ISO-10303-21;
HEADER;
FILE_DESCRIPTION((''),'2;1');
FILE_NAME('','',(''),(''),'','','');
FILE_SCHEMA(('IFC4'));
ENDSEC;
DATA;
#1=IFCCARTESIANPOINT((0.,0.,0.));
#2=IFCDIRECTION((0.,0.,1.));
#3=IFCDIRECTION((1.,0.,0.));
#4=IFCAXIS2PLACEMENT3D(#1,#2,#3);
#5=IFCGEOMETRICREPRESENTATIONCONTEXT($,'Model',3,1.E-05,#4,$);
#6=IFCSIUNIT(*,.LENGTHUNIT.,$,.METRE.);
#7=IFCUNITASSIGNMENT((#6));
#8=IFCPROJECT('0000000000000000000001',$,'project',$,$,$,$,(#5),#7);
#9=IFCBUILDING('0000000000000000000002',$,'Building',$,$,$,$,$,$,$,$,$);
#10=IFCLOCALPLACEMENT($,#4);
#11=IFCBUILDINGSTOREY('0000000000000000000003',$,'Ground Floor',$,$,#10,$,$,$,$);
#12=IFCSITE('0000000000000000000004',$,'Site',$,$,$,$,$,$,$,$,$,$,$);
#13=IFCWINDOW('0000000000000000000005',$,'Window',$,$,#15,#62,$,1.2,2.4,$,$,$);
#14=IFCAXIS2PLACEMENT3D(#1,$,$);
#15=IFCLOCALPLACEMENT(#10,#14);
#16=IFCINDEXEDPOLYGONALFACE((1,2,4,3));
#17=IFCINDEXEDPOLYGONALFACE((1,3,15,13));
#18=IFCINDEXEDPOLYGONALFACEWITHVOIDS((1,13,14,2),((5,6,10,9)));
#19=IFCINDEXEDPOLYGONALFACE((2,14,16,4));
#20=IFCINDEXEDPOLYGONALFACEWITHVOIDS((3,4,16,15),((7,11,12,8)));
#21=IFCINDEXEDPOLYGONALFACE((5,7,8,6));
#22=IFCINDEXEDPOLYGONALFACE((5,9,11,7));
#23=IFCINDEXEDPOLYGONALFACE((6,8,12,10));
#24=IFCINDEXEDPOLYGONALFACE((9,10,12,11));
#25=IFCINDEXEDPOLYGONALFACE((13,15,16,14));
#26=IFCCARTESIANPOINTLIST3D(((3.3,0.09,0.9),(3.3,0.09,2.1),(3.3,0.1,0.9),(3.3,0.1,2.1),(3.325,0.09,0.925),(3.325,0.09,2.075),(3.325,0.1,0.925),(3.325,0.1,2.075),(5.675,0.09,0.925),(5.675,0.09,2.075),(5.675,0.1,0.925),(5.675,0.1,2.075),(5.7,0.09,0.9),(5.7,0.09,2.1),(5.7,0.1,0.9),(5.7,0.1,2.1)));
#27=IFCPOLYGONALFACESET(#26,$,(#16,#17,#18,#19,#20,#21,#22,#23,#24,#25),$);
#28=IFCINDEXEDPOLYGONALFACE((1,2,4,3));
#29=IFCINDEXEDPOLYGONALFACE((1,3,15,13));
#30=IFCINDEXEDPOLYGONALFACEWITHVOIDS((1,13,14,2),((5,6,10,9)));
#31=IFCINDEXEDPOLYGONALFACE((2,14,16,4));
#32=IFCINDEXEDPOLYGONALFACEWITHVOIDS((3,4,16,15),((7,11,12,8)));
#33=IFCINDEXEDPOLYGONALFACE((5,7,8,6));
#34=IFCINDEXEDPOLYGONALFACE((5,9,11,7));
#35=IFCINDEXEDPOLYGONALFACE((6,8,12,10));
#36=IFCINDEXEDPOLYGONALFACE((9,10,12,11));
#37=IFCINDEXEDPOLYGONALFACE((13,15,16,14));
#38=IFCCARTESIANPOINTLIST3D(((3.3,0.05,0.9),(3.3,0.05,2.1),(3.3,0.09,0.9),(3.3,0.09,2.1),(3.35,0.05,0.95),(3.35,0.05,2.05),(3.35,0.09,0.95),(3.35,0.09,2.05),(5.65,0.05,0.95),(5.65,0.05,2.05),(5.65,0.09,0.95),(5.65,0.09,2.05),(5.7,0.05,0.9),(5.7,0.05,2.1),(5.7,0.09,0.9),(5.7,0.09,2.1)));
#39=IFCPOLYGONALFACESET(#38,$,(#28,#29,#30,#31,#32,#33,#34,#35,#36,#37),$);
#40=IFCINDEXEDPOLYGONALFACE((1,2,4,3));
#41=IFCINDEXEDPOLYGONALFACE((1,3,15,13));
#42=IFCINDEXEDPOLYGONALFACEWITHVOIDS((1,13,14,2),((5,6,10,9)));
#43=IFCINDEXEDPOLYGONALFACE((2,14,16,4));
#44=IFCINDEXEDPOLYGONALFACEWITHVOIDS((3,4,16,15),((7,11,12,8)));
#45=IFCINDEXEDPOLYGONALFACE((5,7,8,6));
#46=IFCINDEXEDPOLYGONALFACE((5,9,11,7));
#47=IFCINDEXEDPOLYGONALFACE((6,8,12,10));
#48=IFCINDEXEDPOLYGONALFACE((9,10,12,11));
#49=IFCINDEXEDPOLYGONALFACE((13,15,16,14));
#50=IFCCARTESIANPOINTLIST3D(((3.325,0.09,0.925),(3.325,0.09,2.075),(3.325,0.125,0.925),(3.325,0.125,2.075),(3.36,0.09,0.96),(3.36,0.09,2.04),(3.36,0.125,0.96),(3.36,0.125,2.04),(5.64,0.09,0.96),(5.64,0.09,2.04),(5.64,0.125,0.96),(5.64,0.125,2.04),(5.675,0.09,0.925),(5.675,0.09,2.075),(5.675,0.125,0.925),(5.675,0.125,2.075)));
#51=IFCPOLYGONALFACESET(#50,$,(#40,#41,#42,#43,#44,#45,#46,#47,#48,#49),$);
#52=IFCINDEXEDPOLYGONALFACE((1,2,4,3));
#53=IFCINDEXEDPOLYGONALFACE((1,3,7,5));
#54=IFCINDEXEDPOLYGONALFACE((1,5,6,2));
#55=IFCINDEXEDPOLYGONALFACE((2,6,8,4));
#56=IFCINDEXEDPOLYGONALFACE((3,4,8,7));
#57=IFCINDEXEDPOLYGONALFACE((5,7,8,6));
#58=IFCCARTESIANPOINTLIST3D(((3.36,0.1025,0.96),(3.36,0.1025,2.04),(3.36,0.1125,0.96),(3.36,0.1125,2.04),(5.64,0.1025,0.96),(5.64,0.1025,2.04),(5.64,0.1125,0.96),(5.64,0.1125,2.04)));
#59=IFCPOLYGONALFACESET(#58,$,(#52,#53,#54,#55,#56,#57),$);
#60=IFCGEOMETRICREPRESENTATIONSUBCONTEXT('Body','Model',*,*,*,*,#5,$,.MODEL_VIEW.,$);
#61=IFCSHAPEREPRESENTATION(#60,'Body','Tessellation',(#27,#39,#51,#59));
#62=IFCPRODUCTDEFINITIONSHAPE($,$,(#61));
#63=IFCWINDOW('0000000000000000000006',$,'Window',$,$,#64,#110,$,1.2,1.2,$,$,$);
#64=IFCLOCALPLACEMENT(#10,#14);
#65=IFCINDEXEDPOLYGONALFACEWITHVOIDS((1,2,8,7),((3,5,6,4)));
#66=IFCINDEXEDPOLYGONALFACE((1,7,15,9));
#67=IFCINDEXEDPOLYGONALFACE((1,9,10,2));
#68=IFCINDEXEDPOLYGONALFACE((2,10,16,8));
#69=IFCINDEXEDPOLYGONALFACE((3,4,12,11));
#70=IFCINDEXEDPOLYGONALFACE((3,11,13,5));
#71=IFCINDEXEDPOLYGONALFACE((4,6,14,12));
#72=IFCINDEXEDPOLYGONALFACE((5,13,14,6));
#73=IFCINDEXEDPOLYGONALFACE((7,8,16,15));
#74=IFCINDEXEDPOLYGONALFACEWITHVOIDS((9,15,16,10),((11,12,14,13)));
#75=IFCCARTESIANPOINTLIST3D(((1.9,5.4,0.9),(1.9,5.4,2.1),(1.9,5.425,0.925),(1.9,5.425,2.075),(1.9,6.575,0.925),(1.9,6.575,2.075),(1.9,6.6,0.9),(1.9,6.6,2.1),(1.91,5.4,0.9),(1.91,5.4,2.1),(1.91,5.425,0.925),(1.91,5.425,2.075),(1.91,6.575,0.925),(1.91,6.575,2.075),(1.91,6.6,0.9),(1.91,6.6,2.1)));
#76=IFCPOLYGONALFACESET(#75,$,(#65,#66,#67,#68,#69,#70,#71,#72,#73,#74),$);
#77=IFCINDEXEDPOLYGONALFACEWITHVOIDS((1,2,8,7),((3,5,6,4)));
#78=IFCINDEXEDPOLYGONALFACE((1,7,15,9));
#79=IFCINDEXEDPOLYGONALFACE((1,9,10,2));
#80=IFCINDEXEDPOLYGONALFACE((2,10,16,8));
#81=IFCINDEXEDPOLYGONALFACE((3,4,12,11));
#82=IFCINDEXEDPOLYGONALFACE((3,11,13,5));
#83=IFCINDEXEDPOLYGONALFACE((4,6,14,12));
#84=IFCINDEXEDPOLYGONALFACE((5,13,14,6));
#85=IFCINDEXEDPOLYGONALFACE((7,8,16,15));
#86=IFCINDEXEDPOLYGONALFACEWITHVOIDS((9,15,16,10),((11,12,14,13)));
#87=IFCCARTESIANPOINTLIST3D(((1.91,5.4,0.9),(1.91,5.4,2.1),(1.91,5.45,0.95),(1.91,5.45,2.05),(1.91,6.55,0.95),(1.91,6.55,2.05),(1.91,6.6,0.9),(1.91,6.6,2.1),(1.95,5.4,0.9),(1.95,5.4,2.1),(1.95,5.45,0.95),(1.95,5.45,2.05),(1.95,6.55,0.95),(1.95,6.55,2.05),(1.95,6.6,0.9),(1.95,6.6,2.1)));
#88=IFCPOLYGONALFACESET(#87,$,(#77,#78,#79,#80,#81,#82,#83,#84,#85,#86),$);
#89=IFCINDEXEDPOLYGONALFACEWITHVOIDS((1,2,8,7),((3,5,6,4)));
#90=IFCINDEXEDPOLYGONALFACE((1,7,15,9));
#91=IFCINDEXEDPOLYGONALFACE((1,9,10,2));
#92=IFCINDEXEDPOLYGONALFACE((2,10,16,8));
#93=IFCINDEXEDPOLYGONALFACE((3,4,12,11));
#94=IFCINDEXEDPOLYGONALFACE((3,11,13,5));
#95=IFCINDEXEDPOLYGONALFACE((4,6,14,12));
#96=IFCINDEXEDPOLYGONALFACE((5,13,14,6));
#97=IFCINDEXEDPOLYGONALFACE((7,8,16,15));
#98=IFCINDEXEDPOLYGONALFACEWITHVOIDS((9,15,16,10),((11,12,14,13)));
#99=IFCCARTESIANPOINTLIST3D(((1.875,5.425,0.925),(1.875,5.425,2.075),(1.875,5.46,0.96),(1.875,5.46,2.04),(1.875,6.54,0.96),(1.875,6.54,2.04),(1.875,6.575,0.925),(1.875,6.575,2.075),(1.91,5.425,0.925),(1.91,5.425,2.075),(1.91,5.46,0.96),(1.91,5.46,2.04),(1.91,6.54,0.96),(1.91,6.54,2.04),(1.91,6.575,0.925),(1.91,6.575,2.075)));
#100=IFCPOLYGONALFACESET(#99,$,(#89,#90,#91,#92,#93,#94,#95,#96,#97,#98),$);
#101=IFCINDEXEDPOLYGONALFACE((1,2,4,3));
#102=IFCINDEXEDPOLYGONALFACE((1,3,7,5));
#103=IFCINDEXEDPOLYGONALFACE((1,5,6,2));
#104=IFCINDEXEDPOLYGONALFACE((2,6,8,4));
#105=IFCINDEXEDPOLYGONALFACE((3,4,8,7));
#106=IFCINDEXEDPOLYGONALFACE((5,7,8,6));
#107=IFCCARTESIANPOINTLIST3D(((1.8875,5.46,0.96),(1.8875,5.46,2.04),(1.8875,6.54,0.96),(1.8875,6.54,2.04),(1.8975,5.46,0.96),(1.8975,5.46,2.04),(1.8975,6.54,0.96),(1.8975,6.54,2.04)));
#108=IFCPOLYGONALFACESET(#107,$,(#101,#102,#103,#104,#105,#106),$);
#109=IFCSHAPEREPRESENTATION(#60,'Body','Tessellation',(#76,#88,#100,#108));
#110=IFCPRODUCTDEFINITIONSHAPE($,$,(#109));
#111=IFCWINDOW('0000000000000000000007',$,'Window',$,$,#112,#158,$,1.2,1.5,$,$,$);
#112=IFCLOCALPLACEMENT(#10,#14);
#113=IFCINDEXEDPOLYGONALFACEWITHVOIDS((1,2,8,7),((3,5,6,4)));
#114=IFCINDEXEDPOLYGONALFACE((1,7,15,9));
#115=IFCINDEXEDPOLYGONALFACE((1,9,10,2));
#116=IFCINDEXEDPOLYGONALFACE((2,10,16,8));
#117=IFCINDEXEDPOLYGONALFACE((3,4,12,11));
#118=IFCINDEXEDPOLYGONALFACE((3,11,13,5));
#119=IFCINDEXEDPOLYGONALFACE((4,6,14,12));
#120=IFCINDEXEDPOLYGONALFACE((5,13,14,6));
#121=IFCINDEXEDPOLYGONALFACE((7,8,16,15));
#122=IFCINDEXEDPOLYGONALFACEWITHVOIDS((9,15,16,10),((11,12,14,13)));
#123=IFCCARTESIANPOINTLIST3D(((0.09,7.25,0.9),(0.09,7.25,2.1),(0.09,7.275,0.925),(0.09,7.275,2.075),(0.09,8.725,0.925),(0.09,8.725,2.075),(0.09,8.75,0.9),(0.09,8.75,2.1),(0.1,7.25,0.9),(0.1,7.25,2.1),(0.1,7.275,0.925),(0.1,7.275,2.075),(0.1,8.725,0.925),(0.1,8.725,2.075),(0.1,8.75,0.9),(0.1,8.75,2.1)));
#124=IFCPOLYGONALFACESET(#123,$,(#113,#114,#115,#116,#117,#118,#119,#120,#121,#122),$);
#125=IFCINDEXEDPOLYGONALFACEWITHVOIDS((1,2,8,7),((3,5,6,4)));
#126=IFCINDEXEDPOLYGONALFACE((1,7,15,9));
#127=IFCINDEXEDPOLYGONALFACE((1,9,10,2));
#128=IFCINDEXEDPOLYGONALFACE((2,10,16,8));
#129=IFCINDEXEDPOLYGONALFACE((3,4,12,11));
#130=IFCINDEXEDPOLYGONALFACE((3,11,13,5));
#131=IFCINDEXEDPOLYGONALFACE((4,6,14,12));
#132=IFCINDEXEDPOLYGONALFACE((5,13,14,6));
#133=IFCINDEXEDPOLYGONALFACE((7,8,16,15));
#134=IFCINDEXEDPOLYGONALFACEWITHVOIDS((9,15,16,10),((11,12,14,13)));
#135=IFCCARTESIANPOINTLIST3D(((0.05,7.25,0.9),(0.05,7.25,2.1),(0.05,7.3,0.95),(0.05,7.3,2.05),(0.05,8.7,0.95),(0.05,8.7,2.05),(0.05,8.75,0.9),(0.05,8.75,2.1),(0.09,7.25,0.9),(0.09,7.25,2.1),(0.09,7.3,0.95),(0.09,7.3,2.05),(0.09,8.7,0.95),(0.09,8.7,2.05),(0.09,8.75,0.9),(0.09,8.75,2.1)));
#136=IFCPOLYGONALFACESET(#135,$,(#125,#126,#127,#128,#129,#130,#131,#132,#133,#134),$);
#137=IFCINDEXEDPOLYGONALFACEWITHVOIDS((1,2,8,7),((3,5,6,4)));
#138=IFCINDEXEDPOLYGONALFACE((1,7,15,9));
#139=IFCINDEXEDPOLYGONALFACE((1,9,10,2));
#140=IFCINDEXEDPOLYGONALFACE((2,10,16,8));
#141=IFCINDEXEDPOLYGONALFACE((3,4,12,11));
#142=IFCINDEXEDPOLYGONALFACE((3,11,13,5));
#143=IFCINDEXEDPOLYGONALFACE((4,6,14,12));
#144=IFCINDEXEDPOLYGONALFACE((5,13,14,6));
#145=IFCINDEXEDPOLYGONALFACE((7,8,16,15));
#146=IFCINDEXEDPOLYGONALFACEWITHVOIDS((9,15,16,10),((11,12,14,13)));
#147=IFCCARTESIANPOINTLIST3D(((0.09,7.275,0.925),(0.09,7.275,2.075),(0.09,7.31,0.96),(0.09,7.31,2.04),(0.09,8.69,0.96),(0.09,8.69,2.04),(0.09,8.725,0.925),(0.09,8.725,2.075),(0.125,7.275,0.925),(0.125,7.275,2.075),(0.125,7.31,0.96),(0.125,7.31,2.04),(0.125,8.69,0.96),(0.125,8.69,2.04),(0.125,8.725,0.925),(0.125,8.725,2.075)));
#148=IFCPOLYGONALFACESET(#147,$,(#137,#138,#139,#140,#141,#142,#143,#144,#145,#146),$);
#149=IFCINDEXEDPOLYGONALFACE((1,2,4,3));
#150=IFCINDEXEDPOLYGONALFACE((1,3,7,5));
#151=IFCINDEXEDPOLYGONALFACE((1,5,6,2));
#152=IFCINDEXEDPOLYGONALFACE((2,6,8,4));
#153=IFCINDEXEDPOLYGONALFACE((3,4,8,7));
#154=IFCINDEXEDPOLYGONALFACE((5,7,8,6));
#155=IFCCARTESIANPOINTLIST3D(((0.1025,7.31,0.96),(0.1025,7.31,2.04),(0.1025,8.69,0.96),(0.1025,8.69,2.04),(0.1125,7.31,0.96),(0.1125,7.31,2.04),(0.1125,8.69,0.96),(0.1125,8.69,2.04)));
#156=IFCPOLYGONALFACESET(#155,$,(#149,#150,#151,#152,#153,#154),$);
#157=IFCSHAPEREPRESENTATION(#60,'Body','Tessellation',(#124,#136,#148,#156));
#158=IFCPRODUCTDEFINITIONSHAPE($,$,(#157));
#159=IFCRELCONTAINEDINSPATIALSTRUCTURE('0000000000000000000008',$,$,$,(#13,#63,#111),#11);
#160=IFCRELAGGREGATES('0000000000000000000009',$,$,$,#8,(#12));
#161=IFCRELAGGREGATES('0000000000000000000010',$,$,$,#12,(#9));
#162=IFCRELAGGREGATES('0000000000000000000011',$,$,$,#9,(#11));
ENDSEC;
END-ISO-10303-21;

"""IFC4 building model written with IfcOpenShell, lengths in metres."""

from ifc_helpers import new_model, si_unit, frame, origin_with_axes, place, context, subcontext, project, spatial, line, indexed_curve, outline, extrude, element, save


model = new_model("IFC4")

# Units and contexts
model_context = context("Model", 3, precision=1e-05, world=origin_with_axes())
body_context = subcontext(model_context, "Body", "Model", "MODEL_VIEW")
ifc_project = project(units=[si_unit("LENGTHUNIT", "METRE")], contexts=[model_context])

# Site, building, storey
site = spatial("IfcSite", under=ifc_project, Name="Site")
building = spatial("IfcBuilding", under=site, Name="Building")
storey_placement = place(None, origin_with_axes())
storey = spatial("IfcBuildingStorey", under=building, at=storey_placement, Name="Ground Floor")

# Windows
window_1_placement = place(storey_placement, frame((3.3, 0.0, 0.9), z_axis=(0.0, 0.0, 1.0), x_axis=(1.0, 0.0, 0.0)))
element("IfcWindow", 1, at=window_1_placement, inside=storey, Name="Window", OverallHeight=1.2, OverallWidth=2.4, context=body_context, shape_type="SweptSolid", body=[
    extrude(outline(indexed_curve([(0.0, 0.0), (2.4, 0.0), (2.4, 1.2), (0.0, 1.2)], segments=[line(1, 2, 3, 4, 1)]), holes=[indexed_curve([(0.025, 0.025), (2.375, 0.025), (2.375, 1.175), (0.025, 1.175)], segments=[line(1, 2, 3, 4, 1)])]), frame((0.0, 0.09, 0.0), z_axis=(0.0, -1.0, 0.0), x_axis=(1.0, 0.0, 0.0)), (0.0, 0.0, -1.0), 0.01),
    extrude(outline(indexed_curve([(0.0, 0.0), (2.4, 0.0), (2.4, 1.2), (0.0, 1.2)], segments=[line(1, 2, 3, 4, 1)]), holes=[indexed_curve([(0.05, 0.05), (2.35, 0.05), (2.35, 1.15), (0.05, 1.15)], segments=[line(1, 2, 3, 4, 1)])]), frame((0.0, 0.05, 0.0), z_axis=(0.0, -1.0, 0.0), x_axis=(1.0, 0.0, 0.0)), (0.0, 0.0, -1.0), 0.04),
    extrude(outline(indexed_curve([(0.0, 0.0), (2.35, 0.0), (2.35, 1.15), (0.0, 1.15)], segments=[line(1, 2, 3, 4, 1)]), holes=[indexed_curve([(0.035, 0.035), (2.315, 0.035), (2.315, 1.115), (0.035, 1.115)], segments=[line(1, 2, 3, 4, 1)])]), frame((0.025, 0.09, 0.025), z_axis=(0.0, -1.0, 0.0), x_axis=(1.0, 0.0, 0.0)), (0.0, 0.0, -1.0), 0.035),
    extrude(outline(indexed_curve([(0.035, 0.035), (2.315, 0.035), (2.315, 1.115), (0.035, 1.115)], segments=[line(1, 2, 3, 4, 1)])), frame((0.025, 0.1025, 0.025), z_axis=(0.0, -1.0, 0.0), x_axis=(1.0, 0.0, 0.0)), (0.0, 0.0, -1.0), 0.01),
])
window_2_placement = place(storey_placement, frame((2.0, 5.4, 0.9), z_axis=(0.0, 0.0, 1.0), x_axis=(0.0, 1.0, 0.0)))
element("IfcWindow", 2, at=window_2_placement, inside=storey, Name="Window", OverallHeight=1.2, OverallWidth=1.2, context=body_context, shape_type="SweptSolid", body=[
    extrude(outline(indexed_curve([(0.0, 0.0), (1.2, 0.0), (1.2, 1.2), (0.0, 1.2)], segments=[line(1, 2, 3, 4, 1)]), holes=[indexed_curve([(0.025, 0.025), (1.175, 0.025), (1.175, 1.175), (0.025, 1.175)], segments=[line(1, 2, 3, 4, 1)])]), frame((0.0, 0.09, 0.0), z_axis=(0.0, -1.0, 0.0), x_axis=(1.0, 0.0, 0.0)), (0.0, 0.0, -1.0), 0.01),
    extrude(outline(indexed_curve([(0.0, 0.0), (1.2, 0.0), (1.2, 1.2), (0.0, 1.2)], segments=[line(1, 2, 3, 4, 1)]), holes=[indexed_curve([(0.05, 0.05), (1.15, 0.05), (1.15, 1.15), (0.05, 1.15)], segments=[line(1, 2, 3, 4, 1)])]), frame((0.0, 0.05, 0.0), z_axis=(0.0, -1.0, 0.0), x_axis=(1.0, 0.0, 0.0)), (0.0, 0.0, -1.0), 0.04),
    extrude(outline(indexed_curve([(0.0, 0.0), (1.15, 0.0), (1.15, 1.15), (0.0, 1.15)], segments=[line(1, 2, 3, 4, 1)]), holes=[indexed_curve([(0.035, 0.035), (1.115, 0.035), (1.115, 1.115), (0.035, 1.115)], segments=[line(1, 2, 3, 4, 1)])]), frame((0.025, 0.09, 0.025), z_axis=(0.0, -1.0, 0.0), x_axis=(1.0, 0.0, 0.0)), (0.0, 0.0, -1.0), 0.035),
    extrude(outline(indexed_curve([(0.035, 0.035), (1.115, 0.035), (1.115, 1.115), (0.035, 1.115)], segments=[line(1, 2, 3, 4, 1)])), frame((0.025, 0.1025, 0.025), z_axis=(0.0, -1.0, 0.0), x_axis=(1.0, 0.0, 0.0)), (0.0, 0.0, -1.0), 0.01),
])
window_3_placement = place(storey_placement, frame((0.0, 8.75, 0.9), z_axis=(0.0, 0.0, 1.0), x_axis=(0.0, -1.0, 0.0)))
element("IfcWindow", 3, at=window_3_placement, inside=storey, Name="Window", OverallHeight=1.2, OverallWidth=1.5, context=body_context, shape_type="SweptSolid", body=[
    extrude(outline(indexed_curve([(0.0, 0.0), (1.5, 0.0), (1.5, 1.2), (0.0, 1.2)], segments=[line(1, 2, 3, 4, 1)]), holes=[indexed_curve([(0.025, 0.025), (1.475, 0.025), (1.475, 1.175), (0.025, 1.175)], segments=[line(1, 2, 3, 4, 1)])]), frame((0.0, 0.09, 0.0), z_axis=(0.0, -1.0, 0.0), x_axis=(1.0, 0.0, 0.0)), (0.0, 0.0, -1.0), 0.01),
    extrude(outline(indexed_curve([(0.0, 0.0), (1.5, 0.0), (1.5, 1.2), (0.0, 1.2)], segments=[line(1, 2, 3, 4, 1)]), holes=[indexed_curve([(0.05, 0.05), (1.45, 0.05), (1.45, 1.15), (0.05, 1.15)], segments=[line(1, 2, 3, 4, 1)])]), frame((0.0, 0.05, 0.0), z_axis=(0.0, -1.0, 0.0), x_axis=(1.0, 0.0, 0.0)), (0.0, 0.0, -1.0), 0.04),
    extrude(outline(indexed_curve([(0.0, 0.0), (1.45, 0.0), (1.45, 1.15), (0.0, 1.15)], segments=[line(1, 2, 3, 4, 1)]), holes=[indexed_curve([(0.035, 0.035), (1.415, 0.035), (1.415, 1.115), (0.035, 1.115)], segments=[line(1, 2, 3, 4, 1)])]), frame((0.025, 0.09, 0.025), z_axis=(0.0, -1.0, 0.0), x_axis=(1.0, 0.0, 0.0)), (0.0, 0.0, -1.0), 0.035),
    extrude(outline(indexed_curve([(0.035, 0.035), (1.415, 0.035), (1.415, 1.115), (0.035, 1.115)], segments=[line(1, 2, 3, 4, 1)])), frame((0.025, 0.1025, 0.025), z_axis=(0.0, -1.0, 0.0), x_axis=(1.0, 0.0, 0.0)), (0.0, 0.0, -1.0), 0.01),
])

save(model, "model.ifc")
